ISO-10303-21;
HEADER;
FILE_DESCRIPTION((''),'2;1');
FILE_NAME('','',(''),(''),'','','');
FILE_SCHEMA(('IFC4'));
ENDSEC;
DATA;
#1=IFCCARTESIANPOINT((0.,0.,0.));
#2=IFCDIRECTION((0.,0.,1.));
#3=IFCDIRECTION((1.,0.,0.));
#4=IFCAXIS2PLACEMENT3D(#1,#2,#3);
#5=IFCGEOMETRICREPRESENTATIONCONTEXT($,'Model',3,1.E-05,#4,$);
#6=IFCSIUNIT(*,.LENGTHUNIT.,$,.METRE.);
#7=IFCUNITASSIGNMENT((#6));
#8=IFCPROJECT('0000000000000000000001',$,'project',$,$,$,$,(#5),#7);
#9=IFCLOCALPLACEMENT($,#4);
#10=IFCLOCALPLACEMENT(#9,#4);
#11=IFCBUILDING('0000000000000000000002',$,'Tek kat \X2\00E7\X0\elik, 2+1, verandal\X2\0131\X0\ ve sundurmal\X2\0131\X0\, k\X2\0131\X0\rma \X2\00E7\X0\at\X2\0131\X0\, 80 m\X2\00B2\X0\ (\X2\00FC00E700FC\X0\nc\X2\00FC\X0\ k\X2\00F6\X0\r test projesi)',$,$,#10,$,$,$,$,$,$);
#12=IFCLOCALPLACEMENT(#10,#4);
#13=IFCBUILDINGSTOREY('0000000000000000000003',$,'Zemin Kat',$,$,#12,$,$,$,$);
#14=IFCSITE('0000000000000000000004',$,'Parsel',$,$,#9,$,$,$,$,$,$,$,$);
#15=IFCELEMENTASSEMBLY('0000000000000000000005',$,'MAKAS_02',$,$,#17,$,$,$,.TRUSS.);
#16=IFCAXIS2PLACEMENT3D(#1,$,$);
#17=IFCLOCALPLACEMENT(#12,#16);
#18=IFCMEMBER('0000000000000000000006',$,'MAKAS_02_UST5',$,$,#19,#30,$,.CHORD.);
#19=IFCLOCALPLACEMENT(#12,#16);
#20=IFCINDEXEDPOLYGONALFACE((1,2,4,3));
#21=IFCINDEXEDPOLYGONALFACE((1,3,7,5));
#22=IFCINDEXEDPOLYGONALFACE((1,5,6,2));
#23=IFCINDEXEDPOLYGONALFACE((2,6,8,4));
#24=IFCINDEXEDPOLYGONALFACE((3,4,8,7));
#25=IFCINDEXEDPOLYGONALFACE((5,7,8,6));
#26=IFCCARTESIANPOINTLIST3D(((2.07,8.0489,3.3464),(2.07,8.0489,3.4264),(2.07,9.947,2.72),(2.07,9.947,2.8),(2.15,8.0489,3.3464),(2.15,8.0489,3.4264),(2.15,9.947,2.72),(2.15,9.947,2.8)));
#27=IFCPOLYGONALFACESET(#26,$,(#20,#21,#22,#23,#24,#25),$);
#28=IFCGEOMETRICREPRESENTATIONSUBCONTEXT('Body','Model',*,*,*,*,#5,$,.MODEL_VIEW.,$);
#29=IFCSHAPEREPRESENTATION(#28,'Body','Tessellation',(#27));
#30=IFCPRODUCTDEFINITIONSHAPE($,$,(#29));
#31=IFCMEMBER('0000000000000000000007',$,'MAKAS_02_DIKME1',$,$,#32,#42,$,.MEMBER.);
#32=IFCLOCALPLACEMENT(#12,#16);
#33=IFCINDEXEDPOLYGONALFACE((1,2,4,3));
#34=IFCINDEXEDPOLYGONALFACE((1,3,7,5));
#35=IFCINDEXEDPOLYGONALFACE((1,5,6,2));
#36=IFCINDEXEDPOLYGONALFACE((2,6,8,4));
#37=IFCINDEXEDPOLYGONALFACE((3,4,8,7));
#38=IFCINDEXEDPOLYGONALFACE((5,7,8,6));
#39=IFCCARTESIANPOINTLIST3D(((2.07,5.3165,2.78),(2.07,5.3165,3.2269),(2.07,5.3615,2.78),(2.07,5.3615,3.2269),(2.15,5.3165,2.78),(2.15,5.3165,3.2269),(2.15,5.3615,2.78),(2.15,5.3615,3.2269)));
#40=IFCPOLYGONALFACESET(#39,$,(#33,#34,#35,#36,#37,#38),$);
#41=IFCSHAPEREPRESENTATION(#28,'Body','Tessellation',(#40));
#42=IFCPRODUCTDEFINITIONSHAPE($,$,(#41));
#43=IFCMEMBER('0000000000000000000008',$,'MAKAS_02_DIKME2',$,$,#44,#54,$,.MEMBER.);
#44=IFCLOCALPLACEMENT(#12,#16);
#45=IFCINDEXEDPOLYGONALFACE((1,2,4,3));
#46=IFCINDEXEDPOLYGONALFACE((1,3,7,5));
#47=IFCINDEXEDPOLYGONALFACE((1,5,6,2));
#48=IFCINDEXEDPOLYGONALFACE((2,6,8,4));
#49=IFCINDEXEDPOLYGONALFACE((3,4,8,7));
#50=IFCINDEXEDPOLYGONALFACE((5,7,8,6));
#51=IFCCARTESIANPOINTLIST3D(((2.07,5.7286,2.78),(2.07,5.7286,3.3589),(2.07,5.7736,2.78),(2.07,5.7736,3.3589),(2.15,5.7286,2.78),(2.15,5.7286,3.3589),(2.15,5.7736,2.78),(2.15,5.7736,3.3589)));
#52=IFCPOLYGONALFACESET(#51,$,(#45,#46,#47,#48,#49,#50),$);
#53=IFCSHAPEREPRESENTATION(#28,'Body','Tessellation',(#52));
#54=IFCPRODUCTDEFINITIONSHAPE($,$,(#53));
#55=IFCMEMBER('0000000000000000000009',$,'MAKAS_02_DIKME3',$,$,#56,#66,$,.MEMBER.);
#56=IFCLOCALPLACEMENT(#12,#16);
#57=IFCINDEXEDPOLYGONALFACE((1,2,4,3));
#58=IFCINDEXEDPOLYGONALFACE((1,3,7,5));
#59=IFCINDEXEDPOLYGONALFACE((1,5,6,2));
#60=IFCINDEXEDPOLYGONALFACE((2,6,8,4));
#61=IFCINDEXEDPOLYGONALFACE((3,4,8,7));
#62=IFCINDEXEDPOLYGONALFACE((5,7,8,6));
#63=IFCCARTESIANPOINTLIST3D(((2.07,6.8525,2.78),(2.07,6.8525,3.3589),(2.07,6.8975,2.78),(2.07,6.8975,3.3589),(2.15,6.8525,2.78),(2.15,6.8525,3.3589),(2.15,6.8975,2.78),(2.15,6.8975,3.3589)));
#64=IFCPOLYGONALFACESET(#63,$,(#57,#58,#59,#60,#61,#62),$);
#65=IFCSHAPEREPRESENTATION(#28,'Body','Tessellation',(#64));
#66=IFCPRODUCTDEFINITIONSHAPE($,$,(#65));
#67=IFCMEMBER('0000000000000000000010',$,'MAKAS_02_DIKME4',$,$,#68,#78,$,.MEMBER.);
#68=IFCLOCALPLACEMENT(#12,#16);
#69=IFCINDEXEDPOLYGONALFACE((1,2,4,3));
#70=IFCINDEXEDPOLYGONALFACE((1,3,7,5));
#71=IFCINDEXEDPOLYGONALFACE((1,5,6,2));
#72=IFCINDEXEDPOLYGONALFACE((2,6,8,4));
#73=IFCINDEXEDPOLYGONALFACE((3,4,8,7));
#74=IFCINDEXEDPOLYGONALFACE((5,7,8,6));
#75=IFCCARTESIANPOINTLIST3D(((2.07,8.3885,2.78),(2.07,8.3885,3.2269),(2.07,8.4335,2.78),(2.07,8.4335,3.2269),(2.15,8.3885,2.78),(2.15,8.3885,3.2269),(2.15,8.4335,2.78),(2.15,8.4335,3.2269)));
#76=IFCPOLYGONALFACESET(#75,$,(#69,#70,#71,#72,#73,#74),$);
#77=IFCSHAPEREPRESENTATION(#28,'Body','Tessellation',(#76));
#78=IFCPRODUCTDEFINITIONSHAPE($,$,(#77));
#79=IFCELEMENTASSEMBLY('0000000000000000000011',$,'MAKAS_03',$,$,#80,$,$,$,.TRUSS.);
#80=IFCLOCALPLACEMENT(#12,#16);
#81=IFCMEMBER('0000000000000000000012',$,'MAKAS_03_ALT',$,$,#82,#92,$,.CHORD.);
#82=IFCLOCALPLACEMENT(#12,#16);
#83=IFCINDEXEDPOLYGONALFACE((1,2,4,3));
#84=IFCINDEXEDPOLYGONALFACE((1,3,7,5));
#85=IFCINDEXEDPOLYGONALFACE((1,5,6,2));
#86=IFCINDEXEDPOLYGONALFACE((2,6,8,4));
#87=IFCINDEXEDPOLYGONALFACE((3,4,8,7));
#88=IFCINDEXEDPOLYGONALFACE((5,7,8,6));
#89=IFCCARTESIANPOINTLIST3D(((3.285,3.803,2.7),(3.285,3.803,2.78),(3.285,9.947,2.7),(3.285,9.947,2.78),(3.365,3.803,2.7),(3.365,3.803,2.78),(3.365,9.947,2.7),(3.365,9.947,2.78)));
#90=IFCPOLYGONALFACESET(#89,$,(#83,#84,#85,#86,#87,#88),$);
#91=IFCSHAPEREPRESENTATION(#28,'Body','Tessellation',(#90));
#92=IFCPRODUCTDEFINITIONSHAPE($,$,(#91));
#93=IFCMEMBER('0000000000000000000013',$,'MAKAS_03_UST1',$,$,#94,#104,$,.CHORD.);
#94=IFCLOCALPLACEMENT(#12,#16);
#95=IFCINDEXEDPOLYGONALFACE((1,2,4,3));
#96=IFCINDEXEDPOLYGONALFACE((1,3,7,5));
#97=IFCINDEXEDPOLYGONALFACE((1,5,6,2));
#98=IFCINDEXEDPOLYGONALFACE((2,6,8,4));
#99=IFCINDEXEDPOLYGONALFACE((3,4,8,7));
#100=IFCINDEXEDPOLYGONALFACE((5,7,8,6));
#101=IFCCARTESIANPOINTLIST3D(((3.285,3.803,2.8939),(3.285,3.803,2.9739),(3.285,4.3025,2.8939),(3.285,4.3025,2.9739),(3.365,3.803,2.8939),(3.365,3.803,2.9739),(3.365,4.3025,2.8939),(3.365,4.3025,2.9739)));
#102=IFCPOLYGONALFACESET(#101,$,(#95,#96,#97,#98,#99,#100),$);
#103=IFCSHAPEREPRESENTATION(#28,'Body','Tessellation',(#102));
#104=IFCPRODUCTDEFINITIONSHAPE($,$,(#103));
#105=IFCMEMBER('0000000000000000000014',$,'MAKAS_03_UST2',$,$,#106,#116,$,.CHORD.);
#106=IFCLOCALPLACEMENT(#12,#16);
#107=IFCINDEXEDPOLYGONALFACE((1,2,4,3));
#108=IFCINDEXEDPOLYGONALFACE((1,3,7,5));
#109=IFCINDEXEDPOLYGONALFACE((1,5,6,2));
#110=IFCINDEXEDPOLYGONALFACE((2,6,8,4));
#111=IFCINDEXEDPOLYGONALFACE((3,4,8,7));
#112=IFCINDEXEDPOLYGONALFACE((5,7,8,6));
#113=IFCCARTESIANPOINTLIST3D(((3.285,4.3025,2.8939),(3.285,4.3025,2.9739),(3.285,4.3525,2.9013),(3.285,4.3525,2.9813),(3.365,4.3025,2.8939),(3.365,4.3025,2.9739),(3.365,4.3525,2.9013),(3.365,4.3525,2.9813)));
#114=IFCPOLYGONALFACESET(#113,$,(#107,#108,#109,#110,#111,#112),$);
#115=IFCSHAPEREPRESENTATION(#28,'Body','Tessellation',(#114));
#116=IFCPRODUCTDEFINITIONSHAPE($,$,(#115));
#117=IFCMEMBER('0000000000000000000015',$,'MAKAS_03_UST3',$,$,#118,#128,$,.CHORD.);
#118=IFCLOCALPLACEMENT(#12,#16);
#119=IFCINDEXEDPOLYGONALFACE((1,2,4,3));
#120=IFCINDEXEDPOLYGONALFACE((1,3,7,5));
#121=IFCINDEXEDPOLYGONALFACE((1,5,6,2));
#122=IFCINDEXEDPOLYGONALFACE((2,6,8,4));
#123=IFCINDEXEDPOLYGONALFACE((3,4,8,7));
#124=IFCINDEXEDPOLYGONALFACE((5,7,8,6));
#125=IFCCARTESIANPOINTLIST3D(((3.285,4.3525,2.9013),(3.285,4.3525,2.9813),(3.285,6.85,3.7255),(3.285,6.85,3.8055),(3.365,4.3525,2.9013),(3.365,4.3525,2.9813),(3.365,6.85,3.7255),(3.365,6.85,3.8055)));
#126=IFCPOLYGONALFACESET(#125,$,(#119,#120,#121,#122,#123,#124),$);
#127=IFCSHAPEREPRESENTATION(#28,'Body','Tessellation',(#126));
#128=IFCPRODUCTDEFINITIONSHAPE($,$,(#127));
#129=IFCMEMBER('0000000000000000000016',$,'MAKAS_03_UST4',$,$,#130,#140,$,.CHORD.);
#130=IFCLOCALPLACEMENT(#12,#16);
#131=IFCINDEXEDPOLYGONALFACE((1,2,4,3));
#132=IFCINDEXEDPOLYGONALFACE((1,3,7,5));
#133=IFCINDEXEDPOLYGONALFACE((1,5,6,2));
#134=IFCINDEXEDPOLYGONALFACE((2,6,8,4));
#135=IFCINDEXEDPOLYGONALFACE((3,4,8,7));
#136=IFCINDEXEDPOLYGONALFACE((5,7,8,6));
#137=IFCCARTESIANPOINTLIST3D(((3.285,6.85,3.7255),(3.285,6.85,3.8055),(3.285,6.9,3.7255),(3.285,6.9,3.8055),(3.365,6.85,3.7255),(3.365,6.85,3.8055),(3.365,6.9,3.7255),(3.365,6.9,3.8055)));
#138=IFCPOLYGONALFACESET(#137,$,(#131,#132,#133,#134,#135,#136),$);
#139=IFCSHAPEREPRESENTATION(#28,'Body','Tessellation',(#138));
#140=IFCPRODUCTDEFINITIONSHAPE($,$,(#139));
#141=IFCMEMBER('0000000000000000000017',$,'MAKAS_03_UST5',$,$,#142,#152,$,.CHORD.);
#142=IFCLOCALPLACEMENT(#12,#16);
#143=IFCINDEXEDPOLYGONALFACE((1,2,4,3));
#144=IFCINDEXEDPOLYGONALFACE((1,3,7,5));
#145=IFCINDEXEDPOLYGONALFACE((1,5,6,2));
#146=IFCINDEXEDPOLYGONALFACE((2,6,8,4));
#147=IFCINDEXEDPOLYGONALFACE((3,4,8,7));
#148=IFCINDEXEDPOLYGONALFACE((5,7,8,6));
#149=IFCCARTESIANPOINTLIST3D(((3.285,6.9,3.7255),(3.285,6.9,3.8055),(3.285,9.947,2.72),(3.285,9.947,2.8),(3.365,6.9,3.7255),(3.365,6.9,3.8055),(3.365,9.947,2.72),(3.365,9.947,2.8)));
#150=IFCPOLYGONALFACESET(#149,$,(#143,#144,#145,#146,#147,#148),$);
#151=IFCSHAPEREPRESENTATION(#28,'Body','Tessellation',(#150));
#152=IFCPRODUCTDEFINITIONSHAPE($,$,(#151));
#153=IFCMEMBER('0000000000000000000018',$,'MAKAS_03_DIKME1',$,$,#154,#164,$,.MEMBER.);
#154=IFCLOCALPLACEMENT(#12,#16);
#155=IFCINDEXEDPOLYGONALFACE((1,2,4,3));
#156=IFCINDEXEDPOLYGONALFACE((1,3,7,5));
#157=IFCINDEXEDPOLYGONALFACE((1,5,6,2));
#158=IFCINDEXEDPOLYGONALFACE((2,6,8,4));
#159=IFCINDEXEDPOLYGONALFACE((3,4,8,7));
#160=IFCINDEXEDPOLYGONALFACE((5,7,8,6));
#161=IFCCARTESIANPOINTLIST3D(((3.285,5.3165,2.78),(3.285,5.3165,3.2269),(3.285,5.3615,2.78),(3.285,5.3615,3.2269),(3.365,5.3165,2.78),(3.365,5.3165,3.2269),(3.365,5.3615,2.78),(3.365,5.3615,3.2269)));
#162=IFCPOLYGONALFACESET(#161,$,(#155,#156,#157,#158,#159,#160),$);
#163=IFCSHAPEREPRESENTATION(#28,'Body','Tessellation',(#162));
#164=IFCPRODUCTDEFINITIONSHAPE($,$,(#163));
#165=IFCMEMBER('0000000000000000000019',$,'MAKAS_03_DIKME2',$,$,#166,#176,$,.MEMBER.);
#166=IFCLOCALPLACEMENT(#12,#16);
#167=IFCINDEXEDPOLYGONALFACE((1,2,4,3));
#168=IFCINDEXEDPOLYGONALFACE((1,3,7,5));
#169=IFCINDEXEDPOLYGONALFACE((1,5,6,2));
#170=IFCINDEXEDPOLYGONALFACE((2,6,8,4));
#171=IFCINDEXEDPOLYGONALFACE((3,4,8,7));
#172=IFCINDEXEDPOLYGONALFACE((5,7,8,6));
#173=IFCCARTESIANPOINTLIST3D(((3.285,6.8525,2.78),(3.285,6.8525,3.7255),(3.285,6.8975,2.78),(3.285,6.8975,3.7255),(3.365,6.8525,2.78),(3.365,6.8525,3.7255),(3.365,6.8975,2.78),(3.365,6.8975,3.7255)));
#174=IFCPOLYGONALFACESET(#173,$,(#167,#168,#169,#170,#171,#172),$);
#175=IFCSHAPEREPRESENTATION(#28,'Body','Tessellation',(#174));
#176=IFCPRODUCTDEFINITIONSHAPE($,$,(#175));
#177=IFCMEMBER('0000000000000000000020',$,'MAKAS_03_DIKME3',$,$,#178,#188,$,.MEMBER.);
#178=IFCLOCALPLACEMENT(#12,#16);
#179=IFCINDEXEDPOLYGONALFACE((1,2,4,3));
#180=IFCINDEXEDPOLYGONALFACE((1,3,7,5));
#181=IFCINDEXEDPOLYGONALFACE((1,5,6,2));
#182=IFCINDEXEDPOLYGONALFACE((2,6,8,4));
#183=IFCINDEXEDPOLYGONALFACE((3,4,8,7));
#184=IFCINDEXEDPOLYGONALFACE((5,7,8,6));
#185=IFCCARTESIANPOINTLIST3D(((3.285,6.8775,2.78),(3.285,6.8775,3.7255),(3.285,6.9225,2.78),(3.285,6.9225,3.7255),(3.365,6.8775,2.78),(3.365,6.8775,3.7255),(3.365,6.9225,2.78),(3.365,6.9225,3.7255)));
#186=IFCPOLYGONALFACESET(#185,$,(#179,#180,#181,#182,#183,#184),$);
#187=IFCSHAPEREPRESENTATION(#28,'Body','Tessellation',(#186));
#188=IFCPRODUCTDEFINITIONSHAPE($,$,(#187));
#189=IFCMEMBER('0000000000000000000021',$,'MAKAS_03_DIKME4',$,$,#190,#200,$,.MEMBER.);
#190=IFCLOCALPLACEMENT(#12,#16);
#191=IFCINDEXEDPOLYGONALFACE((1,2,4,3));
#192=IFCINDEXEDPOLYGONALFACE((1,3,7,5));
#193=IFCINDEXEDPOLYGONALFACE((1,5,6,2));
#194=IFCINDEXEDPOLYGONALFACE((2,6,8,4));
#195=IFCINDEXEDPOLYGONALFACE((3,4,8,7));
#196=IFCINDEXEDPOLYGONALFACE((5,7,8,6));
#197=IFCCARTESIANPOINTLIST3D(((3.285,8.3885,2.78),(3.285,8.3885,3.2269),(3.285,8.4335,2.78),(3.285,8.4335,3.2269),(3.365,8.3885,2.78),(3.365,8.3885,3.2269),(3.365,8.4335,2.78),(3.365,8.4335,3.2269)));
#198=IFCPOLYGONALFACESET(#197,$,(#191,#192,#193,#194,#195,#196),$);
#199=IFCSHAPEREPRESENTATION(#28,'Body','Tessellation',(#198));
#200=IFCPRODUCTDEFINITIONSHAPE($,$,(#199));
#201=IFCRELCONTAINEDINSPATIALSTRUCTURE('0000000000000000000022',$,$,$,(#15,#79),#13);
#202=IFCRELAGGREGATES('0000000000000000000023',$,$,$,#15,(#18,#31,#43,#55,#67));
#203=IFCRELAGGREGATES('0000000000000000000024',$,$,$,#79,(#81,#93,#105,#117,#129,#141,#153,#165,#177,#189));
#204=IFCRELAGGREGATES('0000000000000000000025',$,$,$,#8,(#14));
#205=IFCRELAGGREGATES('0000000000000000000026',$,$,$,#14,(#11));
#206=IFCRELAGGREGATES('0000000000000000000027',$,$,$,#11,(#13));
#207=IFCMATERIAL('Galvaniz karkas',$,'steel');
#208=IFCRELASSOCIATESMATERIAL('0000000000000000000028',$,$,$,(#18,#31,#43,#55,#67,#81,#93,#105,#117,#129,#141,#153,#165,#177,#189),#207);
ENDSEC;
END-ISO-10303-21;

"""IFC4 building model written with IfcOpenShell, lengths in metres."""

from ifc_helpers import new_model, si_unit, frame, origin_with_axes, place, context, subcontext, project, spatial, line, indexed_curve, outline, extrude, material, element, aggregate, save


model = new_model("IFC4")

# Units and contexts
model_context = context("Model", 3, precision=1e-05, world=origin_with_axes())
body_context = subcontext(model_context, "Body", "Model", "MODEL_VIEW")
ifc_project = project(units=[si_unit("LENGTHUNIT", "METRE")], contexts=[model_context])

# Site, building, storey
site_placement = place(None, origin_with_axes())
site = spatial("IfcSite", under=ifc_project, at=site_placement, Name="Parsel")
building_placement = place(site_placement, origin_with_axes())
building = spatial("IfcBuilding", under=site, at=building_placement, Name="Tek kat çelik, 2+1, verandalı ve sundurmalı, kırma çatı, 80 m² (üçüncü kör test projesi)")
storey_placement = place(building_placement, origin_with_axes())
storey = spatial("IfcBuildingStorey", under=building, at=storey_placement, Name="Zemin Kat")

# Element assemblies, members
ifc_material_1 = material(Name="Galvaniz karkas", Category="steel")
assembly_1_placement = place(storey_placement, origin_with_axes())
assembly_1 = element("IfcElementAssembly", 1, at=assembly_1_placement, inside=storey, Name="MAKAS_02", PredefinedType="TRUSS")
member_1_placement = place(assembly_1_placement, origin_with_axes())
member_1 = element("IfcMember", 2, at=member_1_placement, material=ifc_material_1, Name="MAKAS_02_UST5", PredefinedType="CHORD", context=body_context, shape_type="SweptSolid", body=[
    extrude(outline(indexed_curve([(8.0489, 3.3464), (9.947, 2.72), (9.947, 2.8), (8.0489, 3.4264)], segments=[line(1, 2, 3, 4, 1)])), frame((2.07, 0.0, 0.0), z_axis=(1.0, 0.0, 0.0), x_axis=(0.0, 1.0, 0.0)), (0.0, 0.0, 1.0), 0.08),
])
member_2_placement = place(assembly_1_placement, origin_with_axes())
member_2 = element("IfcMember", 3, at=member_2_placement, material=ifc_material_1, Name="MAKAS_02_DIKME1", PredefinedType="MEMBER", context=body_context, shape_type="SweptSolid", body=[
    extrude(outline(indexed_curve([(5.3165, 2.78), (5.3615, 2.78), (5.3615, 3.2269), (5.3165, 3.2269)], segments=[line(1, 2, 3, 4, 1)])), frame((2.07, 0.0, 0.0), z_axis=(1.0, 0.0, 0.0), x_axis=(0.0, 1.0, 0.0)), (0.0, 0.0, 1.0), 0.08),
])
member_3_placement = place(assembly_1_placement, origin_with_axes())
member_3 = element("IfcMember", 4, at=member_3_placement, material=ifc_material_1, Name="MAKAS_02_DIKME2", PredefinedType="MEMBER", context=body_context, shape_type="SweptSolid", body=[
    extrude(outline(indexed_curve([(5.7286, 2.78), (5.7736, 2.78), (5.7736, 3.3589), (5.7286, 3.3589)], segments=[line(1, 2, 3, 4, 1)])), frame((2.07, 0.0, 0.0), z_axis=(1.0, 0.0, 0.0), x_axis=(0.0, 1.0, 0.0)), (0.0, 0.0, 1.0), 0.08),
])
member_4_placement = place(assembly_1_placement, origin_with_axes())
member_4 = element("IfcMember", 5, at=member_4_placement, material=ifc_material_1, Name="MAKAS_02_DIKME3", PredefinedType="MEMBER", context=body_context, shape_type="SweptSolid", body=[
    extrude(outline(indexed_curve([(6.8525, 2.78), (6.8975, 2.78), (6.8975, 3.3589), (6.8525, 3.3589)], segments=[line(1, 2, 3, 4, 1)])), frame((2.07, 0.0, 0.0), z_axis=(1.0, 0.0, 0.0), x_axis=(0.0, 1.0, 0.0)), (0.0, 0.0, 1.0), 0.08),
])
member_5_placement = place(assembly_1_placement, origin_with_axes())
member_5 = element("IfcMember", 6, at=member_5_placement, material=ifc_material_1, Name="MAKAS_02_DIKME4", PredefinedType="MEMBER", context=body_context, shape_type="SweptSolid", body=[
    extrude(outline(indexed_curve([(8.3885, 2.78), (8.4335, 2.78), (8.4335, 3.2269), (8.3885, 3.2269)], segments=[line(1, 2, 3, 4, 1)])), frame((2.07, 0.0, 0.0), z_axis=(1.0, 0.0, 0.0), x_axis=(0.0, 1.0, 0.0)), (0.0, 0.0, 1.0), 0.08),
])
aggregate(assembly_1, [member_1, member_2, member_3, member_4, member_5])
assembly_2_placement = place(storey_placement, origin_with_axes())
assembly_2 = element("IfcElementAssembly", 7, at=assembly_2_placement, inside=storey, Name="MAKAS_03", PredefinedType="TRUSS")
member_6_placement = place(assembly_2_placement, origin_with_axes())
member_6 = element("IfcMember", 8, at=member_6_placement, material=ifc_material_1, Name="MAKAS_03_ALT", PredefinedType="CHORD", context=body_context, shape_type="SweptSolid", body=[
    extrude(outline(indexed_curve([(3.803, 2.7), (9.947, 2.7), (9.947, 2.78), (3.803, 2.78)], segments=[line(1, 2, 3, 4, 1)])), frame((3.285, 0.0, 0.0), z_axis=(1.0, 0.0, 0.0), x_axis=(0.0, 1.0, 0.0)), (0.0, 0.0, 1.0), 0.08),
])
member_7_placement = place(assembly_2_placement, origin_with_axes())
member_7 = element("IfcMember", 9, at=member_7_placement, material=ifc_material_1, Name="MAKAS_03_UST1", PredefinedType="CHORD", context=body_context, shape_type="SweptSolid", body=[
    extrude(outline(indexed_curve([(3.803, 2.8939), (4.3025, 2.8939), (4.3025, 2.9739), (3.803, 2.9739)], segments=[line(1, 2, 3, 4, 1)])), frame((3.285, 0.0, 0.0), z_axis=(1.0, 0.0, 0.0), x_axis=(0.0, 1.0, 0.0)), (0.0, 0.0, 1.0), 0.08),
])
member_8_placement = place(assembly_2_placement, origin_with_axes())
member_8 = element("IfcMember", 10, at=member_8_placement, material=ifc_material_1, Name="MAKAS_03_UST2", PredefinedType="CHORD", context=body_context, shape_type="SweptSolid", body=[
    extrude(outline(indexed_curve([(4.3025, 2.8939), (4.3525, 2.9013), (4.3525, 2.9813), (4.3025, 2.9739)], segments=[line(1, 2, 3, 4, 1)])), frame((3.285, 0.0, 0.0), z_axis=(1.0, 0.0, 0.0), x_axis=(0.0, 1.0, 0.0)), (0.0, 0.0, 1.0), 0.08),
])
member_9_placement = place(assembly_2_placement, origin_with_axes())
member_9 = element("IfcMember", 11, at=member_9_placement, material=ifc_material_1, Name="MAKAS_03_UST3", PredefinedType="CHORD", context=body_context, shape_type="SweptSolid", body=[
    extrude(outline(indexed_curve([(4.3525, 2.9013), (6.85, 3.7255), (6.85, 3.8055), (4.3525, 2.9813)], segments=[line(1, 2, 3, 4, 1)])), frame((3.285, 0.0, 0.0), z_axis=(1.0, 0.0, 0.0), x_axis=(0.0, 1.0, 0.0)), (0.0, 0.0, 1.0), 0.08),
])
member_10_placement = place(assembly_2_placement, origin_with_axes())
member_10 = element("IfcMember", 12, at=member_10_placement, material=ifc_material_1, Name="MAKAS_03_UST4", PredefinedType="CHORD", context=body_context, shape_type="SweptSolid", body=[
    extrude(outline(indexed_curve([(6.85, 3.7255), (6.9, 3.7255), (6.9, 3.8055), (6.85, 3.8055)], segments=[line(1, 2, 3, 4, 1)])), frame((3.285, 0.0, 0.0), z_axis=(1.0, 0.0, 0.0), x_axis=(0.0, 1.0, 0.0)), (0.0, 0.0, 1.0), 0.08),
])
member_11_placement = place(assembly_2_placement, origin_with_axes())
member_11 = element("IfcMember", 13, at=member_11_placement, material=ifc_material_1, Name="MAKAS_03_UST5", PredefinedType="CHORD", context=body_context, shape_type="SweptSolid", body=[
    extrude(outline(indexed_curve([(6.9, 3.7255), (9.947, 2.72), (9.947, 2.8), (6.9, 3.8055)], segments=[line(1, 2, 3, 4, 1)])), frame((3.285, 0.0, 0.0), z_axis=(1.0, 0.0, 0.0), x_axis=(0.0, 1.0, 0.0)), (0.0, 0.0, 1.0), 0.08),
])
member_12_placement = place(assembly_2_placement, origin_with_axes())
member_12 = element("IfcMember", 14, at=member_12_placement, material=ifc_material_1, Name="MAKAS_03_DIKME1", PredefinedType="MEMBER", context=body_context, shape_type="SweptSolid", body=[
    extrude(outline(indexed_curve([(5.3165, 2.78), (5.3615, 2.78), (5.3615, 3.2269), (5.3165, 3.2269)], segments=[line(1, 2, 3, 4, 1)])), frame((3.285, 0.0, 0.0), z_axis=(1.0, 0.0, 0.0), x_axis=(0.0, 1.0, 0.0)), (0.0, 0.0, 1.0), 0.08),
])
member_13_placement = place(assembly_2_placement, origin_with_axes())
member_13 = element("IfcMember", 15, at=member_13_placement, material=ifc_material_1, Name="MAKAS_03_DIKME2", PredefinedType="MEMBER", context=body_context, shape_type="SweptSolid", body=[
    extrude(outline(indexed_curve([(6.8525, 2.78), (6.8975, 2.78), (6.8975, 3.7255), (6.8525, 3.7255)], segments=[line(1, 2, 3, 4, 1)])), frame((3.285, 0.0, 0.0), z_axis=(1.0, 0.0, 0.0), x_axis=(0.0, 1.0, 0.0)), (0.0, 0.0, 1.0), 0.08),
])
member_14_placement = place(assembly_2_placement, origin_with_axes())
member_14 = element("IfcMember", 16, at=member_14_placement, material=ifc_material_1, Name="MAKAS_03_DIKME3", PredefinedType="MEMBER", context=body_context, shape_type="SweptSolid", body=[
    extrude(outline(indexed_curve([(6.8775, 2.78), (6.9225, 2.78), (6.9225, 3.7255), (6.8775, 3.7255)], segments=[line(1, 2, 3, 4, 1)])), frame((3.285, 0.0, 0.0), z_axis=(1.0, 0.0, 0.0), x_axis=(0.0, 1.0, 0.0)), (0.0, 0.0, 1.0), 0.08),
])
member_15_placement = place(assembly_2_placement, origin_with_axes())
member_15 = element("IfcMember", 17, at=member_15_placement, material=ifc_material_1, Name="MAKAS_03_DIKME4", PredefinedType="MEMBER", context=body_context, shape_type="SweptSolid", body=[
    extrude(outline(indexed_curve([(8.3885, 2.78), (8.4335, 2.78), (8.4335, 3.2269), (8.3885, 3.2269)], segments=[line(1, 2, 3, 4, 1)])), frame((3.285, 0.0, 0.0), z_axis=(1.0, 0.0, 0.0), x_axis=(0.0, 1.0, 0.0)), (0.0, 0.0, 1.0), 0.08),
])
aggregate(assembly_2, [member_6, member_7, member_8, member_9, member_10, member_11, member_12, member_13, member_14, member_15])

save(model, "model.ifc")
